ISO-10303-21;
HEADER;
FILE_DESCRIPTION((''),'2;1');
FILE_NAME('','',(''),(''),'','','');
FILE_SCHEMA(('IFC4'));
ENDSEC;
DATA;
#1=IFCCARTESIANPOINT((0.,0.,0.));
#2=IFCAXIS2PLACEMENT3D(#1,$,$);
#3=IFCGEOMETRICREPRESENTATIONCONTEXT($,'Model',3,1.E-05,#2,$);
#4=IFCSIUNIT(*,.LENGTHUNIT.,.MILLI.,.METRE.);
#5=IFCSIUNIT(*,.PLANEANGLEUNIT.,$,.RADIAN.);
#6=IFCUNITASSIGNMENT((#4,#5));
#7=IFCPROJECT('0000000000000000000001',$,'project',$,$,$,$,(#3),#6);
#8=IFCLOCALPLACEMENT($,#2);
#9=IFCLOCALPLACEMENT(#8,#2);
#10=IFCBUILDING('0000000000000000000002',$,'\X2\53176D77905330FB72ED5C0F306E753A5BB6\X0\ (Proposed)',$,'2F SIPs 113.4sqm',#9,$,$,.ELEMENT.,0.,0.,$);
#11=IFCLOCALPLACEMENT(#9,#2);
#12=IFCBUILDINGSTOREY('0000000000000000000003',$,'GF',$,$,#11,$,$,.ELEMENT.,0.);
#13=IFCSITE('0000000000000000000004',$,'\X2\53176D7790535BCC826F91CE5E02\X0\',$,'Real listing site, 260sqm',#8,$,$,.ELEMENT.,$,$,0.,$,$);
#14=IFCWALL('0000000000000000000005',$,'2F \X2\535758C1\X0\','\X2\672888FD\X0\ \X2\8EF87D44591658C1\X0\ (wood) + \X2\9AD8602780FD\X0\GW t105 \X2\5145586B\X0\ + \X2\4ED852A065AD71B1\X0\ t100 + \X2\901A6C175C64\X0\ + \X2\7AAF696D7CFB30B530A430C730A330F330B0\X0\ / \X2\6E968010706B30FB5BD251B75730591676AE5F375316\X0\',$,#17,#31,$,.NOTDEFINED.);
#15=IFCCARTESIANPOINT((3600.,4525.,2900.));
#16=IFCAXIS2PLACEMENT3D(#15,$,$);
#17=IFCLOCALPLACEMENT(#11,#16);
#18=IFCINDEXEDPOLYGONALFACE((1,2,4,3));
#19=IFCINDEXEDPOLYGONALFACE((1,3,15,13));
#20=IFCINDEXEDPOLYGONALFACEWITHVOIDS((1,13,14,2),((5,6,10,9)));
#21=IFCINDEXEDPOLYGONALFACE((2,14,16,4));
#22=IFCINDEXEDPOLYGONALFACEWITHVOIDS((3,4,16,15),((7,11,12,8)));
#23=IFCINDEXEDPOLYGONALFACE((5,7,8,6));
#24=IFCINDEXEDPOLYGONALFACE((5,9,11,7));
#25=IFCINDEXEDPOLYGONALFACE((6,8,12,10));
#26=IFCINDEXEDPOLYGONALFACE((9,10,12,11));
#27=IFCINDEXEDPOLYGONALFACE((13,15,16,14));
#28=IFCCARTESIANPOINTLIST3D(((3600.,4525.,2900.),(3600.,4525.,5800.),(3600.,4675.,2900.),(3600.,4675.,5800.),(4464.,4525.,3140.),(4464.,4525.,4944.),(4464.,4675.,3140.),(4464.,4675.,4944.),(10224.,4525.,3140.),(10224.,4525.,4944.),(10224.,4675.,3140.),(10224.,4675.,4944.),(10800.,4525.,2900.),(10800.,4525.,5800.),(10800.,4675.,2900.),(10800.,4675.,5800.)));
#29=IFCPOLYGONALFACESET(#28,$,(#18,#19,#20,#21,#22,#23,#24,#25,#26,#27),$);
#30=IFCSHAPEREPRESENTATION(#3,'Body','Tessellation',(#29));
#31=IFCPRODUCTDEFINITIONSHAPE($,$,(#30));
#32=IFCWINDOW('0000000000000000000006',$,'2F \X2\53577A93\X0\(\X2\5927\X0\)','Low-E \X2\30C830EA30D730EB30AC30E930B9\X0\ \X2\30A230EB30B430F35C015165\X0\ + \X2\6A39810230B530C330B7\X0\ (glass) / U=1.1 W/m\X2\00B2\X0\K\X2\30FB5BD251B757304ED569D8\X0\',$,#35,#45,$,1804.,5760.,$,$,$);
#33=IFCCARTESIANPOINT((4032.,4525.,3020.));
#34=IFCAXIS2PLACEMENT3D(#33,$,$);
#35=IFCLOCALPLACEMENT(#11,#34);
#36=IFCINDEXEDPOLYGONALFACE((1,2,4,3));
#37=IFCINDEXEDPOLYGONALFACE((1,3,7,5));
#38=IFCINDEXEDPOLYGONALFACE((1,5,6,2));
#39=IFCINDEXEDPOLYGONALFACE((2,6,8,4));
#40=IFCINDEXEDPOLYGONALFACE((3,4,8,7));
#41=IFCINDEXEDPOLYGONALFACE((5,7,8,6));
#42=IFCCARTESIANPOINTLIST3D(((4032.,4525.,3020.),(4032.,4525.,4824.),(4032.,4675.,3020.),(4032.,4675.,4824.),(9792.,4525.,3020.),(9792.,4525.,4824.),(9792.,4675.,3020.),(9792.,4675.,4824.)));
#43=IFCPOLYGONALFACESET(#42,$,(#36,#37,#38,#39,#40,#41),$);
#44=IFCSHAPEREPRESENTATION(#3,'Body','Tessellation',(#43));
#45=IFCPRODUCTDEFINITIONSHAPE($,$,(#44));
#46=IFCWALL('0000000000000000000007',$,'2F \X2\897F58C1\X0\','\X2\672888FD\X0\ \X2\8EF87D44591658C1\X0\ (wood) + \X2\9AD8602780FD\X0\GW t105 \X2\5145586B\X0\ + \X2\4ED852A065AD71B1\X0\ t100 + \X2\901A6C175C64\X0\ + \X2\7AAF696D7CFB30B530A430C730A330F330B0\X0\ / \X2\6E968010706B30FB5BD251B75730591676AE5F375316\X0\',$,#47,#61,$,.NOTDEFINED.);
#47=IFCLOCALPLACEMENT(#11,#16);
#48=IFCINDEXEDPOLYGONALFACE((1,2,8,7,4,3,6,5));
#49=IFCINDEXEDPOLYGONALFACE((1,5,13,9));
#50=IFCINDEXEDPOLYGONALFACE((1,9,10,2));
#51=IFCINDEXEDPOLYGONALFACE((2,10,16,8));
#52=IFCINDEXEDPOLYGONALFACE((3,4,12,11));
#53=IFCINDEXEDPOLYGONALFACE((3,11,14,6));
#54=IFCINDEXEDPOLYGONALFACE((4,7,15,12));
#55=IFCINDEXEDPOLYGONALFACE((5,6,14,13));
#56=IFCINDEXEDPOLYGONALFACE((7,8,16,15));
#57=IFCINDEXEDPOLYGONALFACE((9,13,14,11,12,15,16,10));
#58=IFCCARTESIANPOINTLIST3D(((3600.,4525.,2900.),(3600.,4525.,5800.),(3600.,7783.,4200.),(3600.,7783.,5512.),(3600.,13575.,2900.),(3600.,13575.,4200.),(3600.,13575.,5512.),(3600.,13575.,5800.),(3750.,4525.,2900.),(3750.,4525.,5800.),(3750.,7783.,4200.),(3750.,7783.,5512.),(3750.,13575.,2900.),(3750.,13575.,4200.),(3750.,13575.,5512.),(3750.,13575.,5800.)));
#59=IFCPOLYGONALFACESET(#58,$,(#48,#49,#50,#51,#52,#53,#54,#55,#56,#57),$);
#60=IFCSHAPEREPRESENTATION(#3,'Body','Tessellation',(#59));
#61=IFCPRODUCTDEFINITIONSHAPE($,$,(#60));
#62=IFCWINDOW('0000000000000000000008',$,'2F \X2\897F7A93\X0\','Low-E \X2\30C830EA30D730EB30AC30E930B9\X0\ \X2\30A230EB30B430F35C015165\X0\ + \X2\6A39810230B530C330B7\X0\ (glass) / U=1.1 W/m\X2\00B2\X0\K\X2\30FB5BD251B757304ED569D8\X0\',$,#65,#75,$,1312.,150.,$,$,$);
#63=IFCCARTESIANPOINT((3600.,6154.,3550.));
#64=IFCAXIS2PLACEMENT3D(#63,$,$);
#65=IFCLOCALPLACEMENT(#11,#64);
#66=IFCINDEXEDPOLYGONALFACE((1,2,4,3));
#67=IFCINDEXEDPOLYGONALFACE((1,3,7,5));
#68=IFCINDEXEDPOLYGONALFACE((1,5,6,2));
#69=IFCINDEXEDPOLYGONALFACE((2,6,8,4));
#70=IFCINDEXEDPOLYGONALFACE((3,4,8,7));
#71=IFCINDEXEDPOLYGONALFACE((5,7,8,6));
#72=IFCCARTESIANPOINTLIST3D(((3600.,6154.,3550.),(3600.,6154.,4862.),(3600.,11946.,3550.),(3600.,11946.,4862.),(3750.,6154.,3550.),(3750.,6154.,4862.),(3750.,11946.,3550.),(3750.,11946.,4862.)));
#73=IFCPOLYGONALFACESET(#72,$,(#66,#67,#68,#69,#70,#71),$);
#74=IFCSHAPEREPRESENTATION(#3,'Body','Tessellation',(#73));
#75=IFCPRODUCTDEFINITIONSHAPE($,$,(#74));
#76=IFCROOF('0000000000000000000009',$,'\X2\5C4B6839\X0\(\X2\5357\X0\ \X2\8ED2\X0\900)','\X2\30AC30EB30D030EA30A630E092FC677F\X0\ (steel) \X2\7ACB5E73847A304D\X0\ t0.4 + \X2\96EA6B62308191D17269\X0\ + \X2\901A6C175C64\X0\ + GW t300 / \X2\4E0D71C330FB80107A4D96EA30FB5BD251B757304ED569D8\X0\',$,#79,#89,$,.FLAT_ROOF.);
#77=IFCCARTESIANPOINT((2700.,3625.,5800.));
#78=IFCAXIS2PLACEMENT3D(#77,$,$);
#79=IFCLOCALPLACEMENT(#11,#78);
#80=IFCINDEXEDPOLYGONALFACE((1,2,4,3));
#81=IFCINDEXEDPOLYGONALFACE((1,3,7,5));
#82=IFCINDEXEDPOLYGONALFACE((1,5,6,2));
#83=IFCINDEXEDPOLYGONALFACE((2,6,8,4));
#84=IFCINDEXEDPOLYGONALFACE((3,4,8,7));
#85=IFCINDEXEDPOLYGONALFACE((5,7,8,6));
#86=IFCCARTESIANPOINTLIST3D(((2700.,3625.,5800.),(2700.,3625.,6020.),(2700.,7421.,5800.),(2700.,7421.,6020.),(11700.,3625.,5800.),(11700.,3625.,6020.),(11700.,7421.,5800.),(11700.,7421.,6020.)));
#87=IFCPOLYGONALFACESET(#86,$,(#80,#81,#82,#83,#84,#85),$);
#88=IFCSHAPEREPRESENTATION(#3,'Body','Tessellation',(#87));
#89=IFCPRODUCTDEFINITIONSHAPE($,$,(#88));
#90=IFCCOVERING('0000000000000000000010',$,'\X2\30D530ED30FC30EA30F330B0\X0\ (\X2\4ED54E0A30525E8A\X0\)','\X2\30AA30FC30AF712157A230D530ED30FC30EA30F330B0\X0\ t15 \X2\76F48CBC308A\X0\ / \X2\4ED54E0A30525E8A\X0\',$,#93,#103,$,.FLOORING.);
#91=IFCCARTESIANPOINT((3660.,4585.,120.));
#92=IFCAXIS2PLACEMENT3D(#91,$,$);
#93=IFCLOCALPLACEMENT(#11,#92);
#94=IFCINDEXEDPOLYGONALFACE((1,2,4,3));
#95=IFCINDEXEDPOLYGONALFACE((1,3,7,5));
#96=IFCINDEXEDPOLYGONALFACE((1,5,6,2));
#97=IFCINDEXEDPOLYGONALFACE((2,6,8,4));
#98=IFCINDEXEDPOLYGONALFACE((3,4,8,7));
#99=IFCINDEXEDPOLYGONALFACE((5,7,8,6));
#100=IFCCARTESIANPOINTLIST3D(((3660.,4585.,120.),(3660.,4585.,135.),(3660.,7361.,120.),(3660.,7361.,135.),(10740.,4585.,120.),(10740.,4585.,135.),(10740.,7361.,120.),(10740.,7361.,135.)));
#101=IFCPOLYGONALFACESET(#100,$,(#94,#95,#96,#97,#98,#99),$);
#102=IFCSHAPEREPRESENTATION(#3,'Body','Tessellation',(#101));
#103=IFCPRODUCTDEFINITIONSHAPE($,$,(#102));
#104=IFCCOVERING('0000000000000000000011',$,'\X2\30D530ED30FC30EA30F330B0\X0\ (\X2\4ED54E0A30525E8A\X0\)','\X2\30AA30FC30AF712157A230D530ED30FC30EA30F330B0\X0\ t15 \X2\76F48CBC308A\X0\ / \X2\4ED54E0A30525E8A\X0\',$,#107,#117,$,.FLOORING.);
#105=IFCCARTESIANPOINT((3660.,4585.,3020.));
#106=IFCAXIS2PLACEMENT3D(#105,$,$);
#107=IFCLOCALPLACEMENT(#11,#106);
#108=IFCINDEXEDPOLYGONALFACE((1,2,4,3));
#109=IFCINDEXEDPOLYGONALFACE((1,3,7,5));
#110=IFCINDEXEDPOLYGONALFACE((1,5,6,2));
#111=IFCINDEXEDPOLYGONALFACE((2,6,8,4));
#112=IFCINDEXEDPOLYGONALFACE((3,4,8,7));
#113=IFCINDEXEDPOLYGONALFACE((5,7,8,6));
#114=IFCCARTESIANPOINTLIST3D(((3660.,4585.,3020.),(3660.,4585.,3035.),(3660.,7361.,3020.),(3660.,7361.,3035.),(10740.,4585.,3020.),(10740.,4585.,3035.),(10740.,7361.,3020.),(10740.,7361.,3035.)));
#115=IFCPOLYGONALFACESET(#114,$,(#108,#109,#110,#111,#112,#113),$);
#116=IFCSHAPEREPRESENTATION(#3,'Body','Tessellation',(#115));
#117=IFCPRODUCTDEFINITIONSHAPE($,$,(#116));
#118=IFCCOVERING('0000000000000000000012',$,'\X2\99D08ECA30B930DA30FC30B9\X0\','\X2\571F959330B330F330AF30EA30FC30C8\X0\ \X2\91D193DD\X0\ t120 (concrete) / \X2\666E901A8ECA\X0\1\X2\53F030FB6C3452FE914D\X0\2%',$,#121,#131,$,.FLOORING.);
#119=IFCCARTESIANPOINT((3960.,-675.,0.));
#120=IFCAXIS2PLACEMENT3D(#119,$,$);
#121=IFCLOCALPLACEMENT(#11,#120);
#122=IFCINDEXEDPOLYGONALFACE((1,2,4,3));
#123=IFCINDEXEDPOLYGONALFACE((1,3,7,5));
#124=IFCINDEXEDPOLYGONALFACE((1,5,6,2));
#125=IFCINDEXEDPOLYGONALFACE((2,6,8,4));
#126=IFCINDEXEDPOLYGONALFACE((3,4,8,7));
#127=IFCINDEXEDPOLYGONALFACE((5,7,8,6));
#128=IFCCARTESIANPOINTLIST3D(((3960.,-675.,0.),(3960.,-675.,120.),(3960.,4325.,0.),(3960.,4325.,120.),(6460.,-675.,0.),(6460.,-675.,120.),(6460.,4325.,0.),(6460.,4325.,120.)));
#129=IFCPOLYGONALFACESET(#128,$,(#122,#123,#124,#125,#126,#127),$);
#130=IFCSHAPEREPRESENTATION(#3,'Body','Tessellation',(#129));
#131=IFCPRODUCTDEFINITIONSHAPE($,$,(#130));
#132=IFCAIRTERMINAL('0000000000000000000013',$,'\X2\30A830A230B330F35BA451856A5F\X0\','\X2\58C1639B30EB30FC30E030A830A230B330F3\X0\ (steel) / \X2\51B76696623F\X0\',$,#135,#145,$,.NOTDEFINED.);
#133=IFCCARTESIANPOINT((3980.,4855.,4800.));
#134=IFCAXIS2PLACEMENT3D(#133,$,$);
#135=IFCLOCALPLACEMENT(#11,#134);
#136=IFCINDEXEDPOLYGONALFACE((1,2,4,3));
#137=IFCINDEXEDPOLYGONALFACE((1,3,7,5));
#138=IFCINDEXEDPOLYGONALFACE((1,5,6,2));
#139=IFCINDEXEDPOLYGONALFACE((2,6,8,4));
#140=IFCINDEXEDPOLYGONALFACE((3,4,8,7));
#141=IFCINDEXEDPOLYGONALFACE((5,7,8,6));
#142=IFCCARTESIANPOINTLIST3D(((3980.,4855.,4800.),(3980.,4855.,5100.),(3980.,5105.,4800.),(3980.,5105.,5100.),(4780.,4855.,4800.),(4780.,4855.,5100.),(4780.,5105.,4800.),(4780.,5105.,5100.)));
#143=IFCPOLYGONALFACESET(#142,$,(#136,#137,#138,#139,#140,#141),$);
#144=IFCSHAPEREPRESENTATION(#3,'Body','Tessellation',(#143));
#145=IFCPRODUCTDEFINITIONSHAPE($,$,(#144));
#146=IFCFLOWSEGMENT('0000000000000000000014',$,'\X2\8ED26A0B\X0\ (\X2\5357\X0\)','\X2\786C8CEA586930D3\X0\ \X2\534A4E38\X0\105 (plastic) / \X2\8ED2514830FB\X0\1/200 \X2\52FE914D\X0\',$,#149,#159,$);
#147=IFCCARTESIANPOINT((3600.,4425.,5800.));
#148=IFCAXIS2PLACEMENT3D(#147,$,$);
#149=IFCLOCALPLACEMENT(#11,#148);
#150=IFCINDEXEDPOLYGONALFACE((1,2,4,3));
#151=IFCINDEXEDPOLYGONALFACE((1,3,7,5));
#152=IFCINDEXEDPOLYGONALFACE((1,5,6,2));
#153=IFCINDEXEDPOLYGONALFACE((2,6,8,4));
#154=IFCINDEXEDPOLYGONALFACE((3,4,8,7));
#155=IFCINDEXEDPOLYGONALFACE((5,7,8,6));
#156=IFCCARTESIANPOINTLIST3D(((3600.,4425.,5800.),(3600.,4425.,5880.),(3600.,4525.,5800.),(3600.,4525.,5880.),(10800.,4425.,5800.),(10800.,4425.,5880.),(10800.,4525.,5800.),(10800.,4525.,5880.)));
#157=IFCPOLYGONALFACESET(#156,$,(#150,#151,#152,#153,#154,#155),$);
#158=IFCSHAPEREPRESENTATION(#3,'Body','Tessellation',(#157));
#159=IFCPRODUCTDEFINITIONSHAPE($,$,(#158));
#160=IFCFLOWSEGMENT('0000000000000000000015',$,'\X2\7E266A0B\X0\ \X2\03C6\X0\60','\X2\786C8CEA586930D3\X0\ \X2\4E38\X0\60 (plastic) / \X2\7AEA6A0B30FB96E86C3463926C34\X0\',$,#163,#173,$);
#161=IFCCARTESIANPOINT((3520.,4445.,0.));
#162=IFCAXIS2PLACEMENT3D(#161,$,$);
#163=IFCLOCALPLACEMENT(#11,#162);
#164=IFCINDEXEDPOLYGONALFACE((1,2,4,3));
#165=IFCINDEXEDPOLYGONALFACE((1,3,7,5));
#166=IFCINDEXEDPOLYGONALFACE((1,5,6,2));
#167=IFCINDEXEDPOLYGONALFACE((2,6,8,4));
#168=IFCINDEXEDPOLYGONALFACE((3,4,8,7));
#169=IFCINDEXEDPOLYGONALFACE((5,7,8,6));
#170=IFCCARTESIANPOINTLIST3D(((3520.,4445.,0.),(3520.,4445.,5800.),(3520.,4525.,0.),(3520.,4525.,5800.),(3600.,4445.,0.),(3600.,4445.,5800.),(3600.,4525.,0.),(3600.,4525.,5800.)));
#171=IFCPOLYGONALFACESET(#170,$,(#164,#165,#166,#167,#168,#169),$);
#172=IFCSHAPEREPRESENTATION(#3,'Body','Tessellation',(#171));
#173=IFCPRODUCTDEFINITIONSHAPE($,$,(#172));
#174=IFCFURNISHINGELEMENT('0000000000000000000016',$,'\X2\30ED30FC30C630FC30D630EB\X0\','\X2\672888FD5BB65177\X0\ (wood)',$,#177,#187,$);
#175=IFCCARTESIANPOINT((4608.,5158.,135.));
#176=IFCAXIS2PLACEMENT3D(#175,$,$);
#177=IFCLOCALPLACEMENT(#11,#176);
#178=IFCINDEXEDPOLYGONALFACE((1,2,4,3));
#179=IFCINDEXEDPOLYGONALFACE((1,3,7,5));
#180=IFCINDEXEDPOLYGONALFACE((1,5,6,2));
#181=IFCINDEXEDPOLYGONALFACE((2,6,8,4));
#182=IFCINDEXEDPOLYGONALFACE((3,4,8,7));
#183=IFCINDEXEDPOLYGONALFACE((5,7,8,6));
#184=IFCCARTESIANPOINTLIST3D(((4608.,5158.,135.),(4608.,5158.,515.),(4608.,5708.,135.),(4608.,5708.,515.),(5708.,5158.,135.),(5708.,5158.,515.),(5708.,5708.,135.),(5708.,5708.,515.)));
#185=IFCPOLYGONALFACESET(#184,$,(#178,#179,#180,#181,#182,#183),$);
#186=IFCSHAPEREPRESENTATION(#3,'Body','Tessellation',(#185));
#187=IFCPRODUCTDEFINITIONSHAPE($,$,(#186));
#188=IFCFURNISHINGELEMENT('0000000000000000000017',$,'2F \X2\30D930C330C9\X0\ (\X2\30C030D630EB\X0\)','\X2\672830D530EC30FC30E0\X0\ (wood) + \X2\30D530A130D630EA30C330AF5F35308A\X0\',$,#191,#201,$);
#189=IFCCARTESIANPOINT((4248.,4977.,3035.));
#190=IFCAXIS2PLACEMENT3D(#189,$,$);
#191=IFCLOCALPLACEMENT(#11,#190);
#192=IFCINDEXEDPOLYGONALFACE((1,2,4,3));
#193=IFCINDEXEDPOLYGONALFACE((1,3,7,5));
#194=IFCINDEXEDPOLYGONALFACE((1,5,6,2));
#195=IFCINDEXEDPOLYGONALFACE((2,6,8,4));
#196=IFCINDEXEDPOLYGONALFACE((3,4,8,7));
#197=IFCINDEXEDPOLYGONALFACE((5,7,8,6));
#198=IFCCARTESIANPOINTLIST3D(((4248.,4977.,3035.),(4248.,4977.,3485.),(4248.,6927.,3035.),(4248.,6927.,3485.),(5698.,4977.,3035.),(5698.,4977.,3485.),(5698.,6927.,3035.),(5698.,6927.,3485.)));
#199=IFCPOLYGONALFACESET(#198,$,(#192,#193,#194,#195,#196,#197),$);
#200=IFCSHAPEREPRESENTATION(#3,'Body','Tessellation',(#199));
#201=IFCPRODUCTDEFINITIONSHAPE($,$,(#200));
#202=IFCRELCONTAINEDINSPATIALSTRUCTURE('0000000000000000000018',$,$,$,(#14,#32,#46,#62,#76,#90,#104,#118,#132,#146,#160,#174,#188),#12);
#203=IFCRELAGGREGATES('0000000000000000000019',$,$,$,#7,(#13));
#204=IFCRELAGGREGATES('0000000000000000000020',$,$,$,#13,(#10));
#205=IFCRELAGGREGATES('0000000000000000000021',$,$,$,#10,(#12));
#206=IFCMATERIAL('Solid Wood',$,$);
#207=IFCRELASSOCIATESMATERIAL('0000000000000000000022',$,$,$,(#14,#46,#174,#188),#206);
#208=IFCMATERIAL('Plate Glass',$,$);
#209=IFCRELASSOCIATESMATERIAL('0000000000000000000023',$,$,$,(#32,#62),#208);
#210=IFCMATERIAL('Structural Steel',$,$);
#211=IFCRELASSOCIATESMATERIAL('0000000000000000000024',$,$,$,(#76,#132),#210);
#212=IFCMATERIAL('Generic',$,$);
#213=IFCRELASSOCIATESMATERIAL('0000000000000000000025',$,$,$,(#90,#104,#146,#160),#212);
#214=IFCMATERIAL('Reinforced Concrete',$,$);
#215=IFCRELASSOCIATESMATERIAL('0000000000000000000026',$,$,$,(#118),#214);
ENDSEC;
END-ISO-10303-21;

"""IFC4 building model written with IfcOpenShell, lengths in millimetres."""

from ifc_helpers import new_model, si_unit, frame, frame_2d, origin, place, context, project, spatial, rectangle, extrude, material, element, fill, save


model = new_model("IFC4")

# Units and contexts
model_context = context("Model", 3, precision=1e-05, world=origin())
ifc_project = project(units=[si_unit("LENGTHUNIT", "METRE", prefix="MILLI"), si_unit("PLANEANGLEUNIT", "RADIAN")], contexts=[model_context])

# Site, building, storey
site_placement = place(None, origin())
site = spatial("IfcSite", under=ifc_project, at=site_placement, Name="北海道富良野市", ObjectType="Real listing site, 260sqm", CompositionType="ELEMENT", RefElevation=0.0)
building_placement = place(site_placement, origin())
building = spatial("IfcBuilding", under=site, at=building_placement, Name="北海道・狭小の町家 (Proposed)", ObjectType="2F SIPs 113.4sqm", CompositionType="ELEMENT", ElevationOfRefHeight=0.0, ElevationOfTerrain=0.0)
storey_placement = place(building_placement, origin())
storey = spatial("IfcBuildingStorey", under=building, at=storey_placement, Name="GF", CompositionType="ELEMENT", Elevation=0.0)

# Shared definitions
ifc_material_1 = material(Name="Solid Wood")

# Shared definitions
ifc_material_2 = material(Name="Reinforced Concrete")

# Shared definitions
ifc_material_3 = material(Name="Plate Glass")

# Walls, openings, windows
wall_1_placement = place(storey_placement, frame((3600.0, 4525.0, 2900.0)))
wall_1 = element("IfcWall", 1, at=wall_1_placement, inside=storey, material=ifc_material_1, Name="2F 南壁", Description="木製 軸組外壁 (wood) + 高性能GW t105 充填 + 付加断熱 t100 + 通気層 + 窯業系サイディング / 準耐火・寒冷地外皮強化", PredefinedType="NOTDEFINED", context=model_context, shape_type="SweptSolid", body=[
    extrude(rectangle(XDim=7200.0, YDim=150.0, at=frame_2d((3600.0, 75.0))), frame((3600.0, 4525.0, 2900.0)), (0.0, 0.0, 1.0), 2900.0),
])
opening_1_placement = place(storey_placement, frame((4032.0, 4525.0, 3020.0)))
opening_1 = element("IfcOpeningElement", 2, at=opening_1_placement, cuts=wall_1, PredefinedType="NOTDEFINED", context=model_context, shape_type="SweptSolid", body=[
    extrude(rectangle(XDim=5760.0, YDim=150.0, at=frame_2d((2880.0, 75.0))), frame((4032.0, 4525.0, 3020.0)), (0.0, 0.0, 1.0), 1804.0),
])
window_1_placement = place(storey_placement, frame((4032.0, 4525.0, 3020.0)))
window_1 = element("IfcWindow", 3, at=window_1_placement, inside=storey, material=ifc_material_3, Name="2F 南窓(大)", Description="Low-E トリプルガラス アルゴン封入 + 樹脂サッシ (glass) / U=1.1 W/m²K・寒冷地仕様", OverallHeight=1804.0, OverallWidth=5760.0, context=model_context, shape_type="SweptSolid", body=[
    extrude(rectangle(XDim=5760.0, YDim=150.0, at=frame_2d((2880.0, 75.0))), frame((4032.0, 4525.0, 3020.0)), (0.0, 0.0, 1.0), 1804.0),
])
fill(opening_1, window_1)
wall_2_placement = place(storey_placement, frame((3600.0, 4525.0, 2900.0)))
wall_2 = element("IfcWall", 4, at=wall_2_placement, inside=storey, material=ifc_material_1, Name="2F 西壁", Description="木製 軸組外壁 (wood) + 高性能GW t105 充填 + 付加断熱 t100 + 通気層 + 窯業系サイディング / 準耐火・寒冷地外皮強化", PredefinedType="NOTDEFINED", context=model_context, shape_type="SweptSolid", body=[
    extrude(rectangle(XDim=150.0, YDim=9050.0, at=frame_2d((75.0, 4525.0))), frame((3600.0, 4525.0, 2900.0)), (0.0, 0.0, 1.0), 2900.0),
])
opening_2_placement = place(storey_placement, frame((3600.0, 6154.0, 3550.0)))
opening_2 = element("IfcOpeningElement", 5, at=opening_2_placement, cuts=wall_2, PredefinedType="NOTDEFINED", context=model_context, shape_type="SweptSolid", body=[
    extrude(rectangle(XDim=150.0, YDim=5792.0, at=frame_2d((75.0, 2896.0))), frame((3600.0, 6154.0, 3550.0)), (0.0, 0.0, 1.0), 1312.0),
])
window_2_placement = place(storey_placement, frame((3600.0, 6154.0, 3550.0)))
window_2 = element("IfcWindow", 6, at=window_2_placement, inside=storey, material=ifc_material_3, Name="2F 西窓", Description="Low-E トリプルガラス アルゴン封入 + 樹脂サッシ (glass) / U=1.1 W/m²K・寒冷地仕様", OverallHeight=1312.0, OverallWidth=150.0, context=model_context, shape_type="SweptSolid", body=[
    extrude(rectangle(XDim=150.0, YDim=5792.0, at=frame_2d((75.0, 2896.0))), frame((3600.0, 6154.0, 3550.0)), (0.0, 0.0, 1.0), 1312.0),
])
fill(opening_2, window_2)

# Roof
ifc_material_4 = material(Name="Structural Steel")
for number, where, name in (
    (7, (2700.0, 3625.0, 5800.0), "屋根(南 軒900)"),
):
    element("IfcRoof", number, at=place(storey_placement, frame(where)), inside=storey, material=ifc_material_4, Name=name, Description="ガルバリウム鋼板 (steel) 立平葺き t0.4 + 雪止め金物 + 通気層 + GW t300 / 不燃・耐積雪・寒冷地仕様", PredefinedType="FLAT_ROOF", context=model_context, shape_type="SweptSolid", body=[
        extrude(rectangle(XDim=9000.0, YDim=3796.0, at=frame_2d((4500.0, 1898.0))), frame((2700.0, 3625.0, 5800.0)), (0.0, 0.0, 1.0), 220.0),
    ])

# Coverings
ifc_material_5 = material(Name="Generic")
covering_1_placement = place(storey_placement, frame((3660.0, 4585.0, 120.0)))
element("IfcCovering", 8, at=covering_1_placement, inside=storey, material=ifc_material_5, Name="フローリング (仕上げ床)", Description="オーク無垢フローリング t15 直貼り / 仕上げ床", PredefinedType="FLOORING", context=model_context, shape_type="SweptSolid", body=[
    extrude(rectangle(XDim=7080.0, YDim=2776.0, at=frame_2d((3540.0, 1388.0))), frame((3660.0, 4585.0, 120.0)), (0.0, 0.0, 1.0), 15.0),
])
covering_2_placement = place(storey_placement, frame((3660.0, 4585.0, 3020.0)))
element("IfcCovering", 9, at=covering_2_placement, inside=storey, material=ifc_material_5, Name="フローリング (仕上げ床)", Description="オーク無垢フローリング t15 直貼り / 仕上げ床", PredefinedType="FLOORING", context=model_context, shape_type="SweptSolid", body=[
    extrude(rectangle(XDim=7080.0, YDim=2776.0, at=frame_2d((3540.0, 1388.0))), frame((3660.0, 4585.0, 3020.0)), (0.0, 0.0, 1.0), 15.0),
])
covering_3_placement = place(storey_placement, frame((3960.0, -675.0, 0.0)))
element("IfcCovering", 10, at=covering_3_placement, inside=storey, material=ifc_material_2, Name="駐車スペース", Description="土間コンクリート 金鏝 t120 (concrete) / 普通車1台・水勾配2%", PredefinedType="FLOORING", context=model_context, shape_type="SweptSolid", body=[
    extrude(rectangle(XDim=2500.0, YDim=5000.0, at=frame_2d((1250.0, 2500.0))), frame((3960.0, -675.0, 0.0)), (0.0, 0.0, 1.0), 120.0),
])

# Air terminal
air_terminal_placement = place(storey_placement, frame((3980.0, 4855.0, 4800.0)))
element("IfcAirTerminal", 11, at=air_terminal_placement, inside=storey, material=ifc_material_4, Name="エアコン室内機", Description="壁掛ルームエアコン (steel) / 冷暖房", PredefinedType="NOTDEFINED", context=model_context, shape_type="SweptSolid", body=[
    extrude(rectangle(XDim=800.0, YDim=250.0, at=frame_2d((400.0, 125.0))), frame((3980.0, 4855.0, 4800.0)), (0.0, 0.0, 1.0), 300.0),
])

# Flow segments
flow_segment_1_placement = place(storey_placement, frame((3600.0, 4425.0, 5800.0)))
element("IfcFlowSegment", 12, at=flow_segment_1_placement, inside=storey, material=ifc_material_5, Name="軒樋 (南)", Description="硬質塩ビ 半丸105 (plastic) / 軒先・1/200 勾配", context=model_context, shape_type="SweptSolid", body=[
    extrude(rectangle(XDim=7200.0, YDim=100.0, at=frame_2d((3600.0, 50.0))), frame((3600.0, 4425.0, 5800.0)), (0.0, 0.0, 1.0), 80.0),
])
flow_segment_2_placement = place(storey_placement, frame((3520.0, 4445.0, 0.0)))
element("IfcFlowSegment", 13, at=flow_segment_2_placement, inside=storey, material=ifc_material_5, Name="縦樋 φ60", Description="硬質塩ビ 丸60 (plastic) / 竪樋・雨水排水", context=model_context, shape_type="SweptSolid", body=[
    extrude(rectangle(XDim=80.0, YDim=80.0, at=frame_2d((40.0, 40.0))), frame((3520.0, 4445.0, 0.0)), (0.0, 0.0, 1.0), 5800.0),
])

# Furnishing elements
furnishing_1_placement = place(storey_placement, frame((4608.0, 5158.0, 135.0)))
element("IfcFurnishingElement", 14, at=furnishing_1_placement, inside=storey, material=ifc_material_1, Name="ローテーブル", Description="木製家具 (wood)", context=model_context, shape_type="SweptSolid", body=[
    extrude(rectangle(XDim=1100.0, YDim=550.0, at=frame_2d((550.0, 275.0))), frame((4608.0, 5158.0, 135.0)), (0.0, 0.0, 1.0), 380.0),
])
furnishing_2_placement = place(storey_placement, frame((4248.0, 4977.0, 3035.0)))
element("IfcFurnishingElement", 15, at=furnishing_2_placement, inside=storey, material=ifc_material_1, Name="2F ベッド (ダブル)", Description="木フレーム (wood) + ファブリック張り", context=model_context, shape_type="SweptSolid", body=[
    extrude(rectangle(XDim=1450.0, YDim=1950.0, at=frame_2d((725.0, 975.0))), frame((4248.0, 4977.0, 3035.0)), (0.0, 0.0, 1.0), 450.0),
])

save(model, "model.ifc")
